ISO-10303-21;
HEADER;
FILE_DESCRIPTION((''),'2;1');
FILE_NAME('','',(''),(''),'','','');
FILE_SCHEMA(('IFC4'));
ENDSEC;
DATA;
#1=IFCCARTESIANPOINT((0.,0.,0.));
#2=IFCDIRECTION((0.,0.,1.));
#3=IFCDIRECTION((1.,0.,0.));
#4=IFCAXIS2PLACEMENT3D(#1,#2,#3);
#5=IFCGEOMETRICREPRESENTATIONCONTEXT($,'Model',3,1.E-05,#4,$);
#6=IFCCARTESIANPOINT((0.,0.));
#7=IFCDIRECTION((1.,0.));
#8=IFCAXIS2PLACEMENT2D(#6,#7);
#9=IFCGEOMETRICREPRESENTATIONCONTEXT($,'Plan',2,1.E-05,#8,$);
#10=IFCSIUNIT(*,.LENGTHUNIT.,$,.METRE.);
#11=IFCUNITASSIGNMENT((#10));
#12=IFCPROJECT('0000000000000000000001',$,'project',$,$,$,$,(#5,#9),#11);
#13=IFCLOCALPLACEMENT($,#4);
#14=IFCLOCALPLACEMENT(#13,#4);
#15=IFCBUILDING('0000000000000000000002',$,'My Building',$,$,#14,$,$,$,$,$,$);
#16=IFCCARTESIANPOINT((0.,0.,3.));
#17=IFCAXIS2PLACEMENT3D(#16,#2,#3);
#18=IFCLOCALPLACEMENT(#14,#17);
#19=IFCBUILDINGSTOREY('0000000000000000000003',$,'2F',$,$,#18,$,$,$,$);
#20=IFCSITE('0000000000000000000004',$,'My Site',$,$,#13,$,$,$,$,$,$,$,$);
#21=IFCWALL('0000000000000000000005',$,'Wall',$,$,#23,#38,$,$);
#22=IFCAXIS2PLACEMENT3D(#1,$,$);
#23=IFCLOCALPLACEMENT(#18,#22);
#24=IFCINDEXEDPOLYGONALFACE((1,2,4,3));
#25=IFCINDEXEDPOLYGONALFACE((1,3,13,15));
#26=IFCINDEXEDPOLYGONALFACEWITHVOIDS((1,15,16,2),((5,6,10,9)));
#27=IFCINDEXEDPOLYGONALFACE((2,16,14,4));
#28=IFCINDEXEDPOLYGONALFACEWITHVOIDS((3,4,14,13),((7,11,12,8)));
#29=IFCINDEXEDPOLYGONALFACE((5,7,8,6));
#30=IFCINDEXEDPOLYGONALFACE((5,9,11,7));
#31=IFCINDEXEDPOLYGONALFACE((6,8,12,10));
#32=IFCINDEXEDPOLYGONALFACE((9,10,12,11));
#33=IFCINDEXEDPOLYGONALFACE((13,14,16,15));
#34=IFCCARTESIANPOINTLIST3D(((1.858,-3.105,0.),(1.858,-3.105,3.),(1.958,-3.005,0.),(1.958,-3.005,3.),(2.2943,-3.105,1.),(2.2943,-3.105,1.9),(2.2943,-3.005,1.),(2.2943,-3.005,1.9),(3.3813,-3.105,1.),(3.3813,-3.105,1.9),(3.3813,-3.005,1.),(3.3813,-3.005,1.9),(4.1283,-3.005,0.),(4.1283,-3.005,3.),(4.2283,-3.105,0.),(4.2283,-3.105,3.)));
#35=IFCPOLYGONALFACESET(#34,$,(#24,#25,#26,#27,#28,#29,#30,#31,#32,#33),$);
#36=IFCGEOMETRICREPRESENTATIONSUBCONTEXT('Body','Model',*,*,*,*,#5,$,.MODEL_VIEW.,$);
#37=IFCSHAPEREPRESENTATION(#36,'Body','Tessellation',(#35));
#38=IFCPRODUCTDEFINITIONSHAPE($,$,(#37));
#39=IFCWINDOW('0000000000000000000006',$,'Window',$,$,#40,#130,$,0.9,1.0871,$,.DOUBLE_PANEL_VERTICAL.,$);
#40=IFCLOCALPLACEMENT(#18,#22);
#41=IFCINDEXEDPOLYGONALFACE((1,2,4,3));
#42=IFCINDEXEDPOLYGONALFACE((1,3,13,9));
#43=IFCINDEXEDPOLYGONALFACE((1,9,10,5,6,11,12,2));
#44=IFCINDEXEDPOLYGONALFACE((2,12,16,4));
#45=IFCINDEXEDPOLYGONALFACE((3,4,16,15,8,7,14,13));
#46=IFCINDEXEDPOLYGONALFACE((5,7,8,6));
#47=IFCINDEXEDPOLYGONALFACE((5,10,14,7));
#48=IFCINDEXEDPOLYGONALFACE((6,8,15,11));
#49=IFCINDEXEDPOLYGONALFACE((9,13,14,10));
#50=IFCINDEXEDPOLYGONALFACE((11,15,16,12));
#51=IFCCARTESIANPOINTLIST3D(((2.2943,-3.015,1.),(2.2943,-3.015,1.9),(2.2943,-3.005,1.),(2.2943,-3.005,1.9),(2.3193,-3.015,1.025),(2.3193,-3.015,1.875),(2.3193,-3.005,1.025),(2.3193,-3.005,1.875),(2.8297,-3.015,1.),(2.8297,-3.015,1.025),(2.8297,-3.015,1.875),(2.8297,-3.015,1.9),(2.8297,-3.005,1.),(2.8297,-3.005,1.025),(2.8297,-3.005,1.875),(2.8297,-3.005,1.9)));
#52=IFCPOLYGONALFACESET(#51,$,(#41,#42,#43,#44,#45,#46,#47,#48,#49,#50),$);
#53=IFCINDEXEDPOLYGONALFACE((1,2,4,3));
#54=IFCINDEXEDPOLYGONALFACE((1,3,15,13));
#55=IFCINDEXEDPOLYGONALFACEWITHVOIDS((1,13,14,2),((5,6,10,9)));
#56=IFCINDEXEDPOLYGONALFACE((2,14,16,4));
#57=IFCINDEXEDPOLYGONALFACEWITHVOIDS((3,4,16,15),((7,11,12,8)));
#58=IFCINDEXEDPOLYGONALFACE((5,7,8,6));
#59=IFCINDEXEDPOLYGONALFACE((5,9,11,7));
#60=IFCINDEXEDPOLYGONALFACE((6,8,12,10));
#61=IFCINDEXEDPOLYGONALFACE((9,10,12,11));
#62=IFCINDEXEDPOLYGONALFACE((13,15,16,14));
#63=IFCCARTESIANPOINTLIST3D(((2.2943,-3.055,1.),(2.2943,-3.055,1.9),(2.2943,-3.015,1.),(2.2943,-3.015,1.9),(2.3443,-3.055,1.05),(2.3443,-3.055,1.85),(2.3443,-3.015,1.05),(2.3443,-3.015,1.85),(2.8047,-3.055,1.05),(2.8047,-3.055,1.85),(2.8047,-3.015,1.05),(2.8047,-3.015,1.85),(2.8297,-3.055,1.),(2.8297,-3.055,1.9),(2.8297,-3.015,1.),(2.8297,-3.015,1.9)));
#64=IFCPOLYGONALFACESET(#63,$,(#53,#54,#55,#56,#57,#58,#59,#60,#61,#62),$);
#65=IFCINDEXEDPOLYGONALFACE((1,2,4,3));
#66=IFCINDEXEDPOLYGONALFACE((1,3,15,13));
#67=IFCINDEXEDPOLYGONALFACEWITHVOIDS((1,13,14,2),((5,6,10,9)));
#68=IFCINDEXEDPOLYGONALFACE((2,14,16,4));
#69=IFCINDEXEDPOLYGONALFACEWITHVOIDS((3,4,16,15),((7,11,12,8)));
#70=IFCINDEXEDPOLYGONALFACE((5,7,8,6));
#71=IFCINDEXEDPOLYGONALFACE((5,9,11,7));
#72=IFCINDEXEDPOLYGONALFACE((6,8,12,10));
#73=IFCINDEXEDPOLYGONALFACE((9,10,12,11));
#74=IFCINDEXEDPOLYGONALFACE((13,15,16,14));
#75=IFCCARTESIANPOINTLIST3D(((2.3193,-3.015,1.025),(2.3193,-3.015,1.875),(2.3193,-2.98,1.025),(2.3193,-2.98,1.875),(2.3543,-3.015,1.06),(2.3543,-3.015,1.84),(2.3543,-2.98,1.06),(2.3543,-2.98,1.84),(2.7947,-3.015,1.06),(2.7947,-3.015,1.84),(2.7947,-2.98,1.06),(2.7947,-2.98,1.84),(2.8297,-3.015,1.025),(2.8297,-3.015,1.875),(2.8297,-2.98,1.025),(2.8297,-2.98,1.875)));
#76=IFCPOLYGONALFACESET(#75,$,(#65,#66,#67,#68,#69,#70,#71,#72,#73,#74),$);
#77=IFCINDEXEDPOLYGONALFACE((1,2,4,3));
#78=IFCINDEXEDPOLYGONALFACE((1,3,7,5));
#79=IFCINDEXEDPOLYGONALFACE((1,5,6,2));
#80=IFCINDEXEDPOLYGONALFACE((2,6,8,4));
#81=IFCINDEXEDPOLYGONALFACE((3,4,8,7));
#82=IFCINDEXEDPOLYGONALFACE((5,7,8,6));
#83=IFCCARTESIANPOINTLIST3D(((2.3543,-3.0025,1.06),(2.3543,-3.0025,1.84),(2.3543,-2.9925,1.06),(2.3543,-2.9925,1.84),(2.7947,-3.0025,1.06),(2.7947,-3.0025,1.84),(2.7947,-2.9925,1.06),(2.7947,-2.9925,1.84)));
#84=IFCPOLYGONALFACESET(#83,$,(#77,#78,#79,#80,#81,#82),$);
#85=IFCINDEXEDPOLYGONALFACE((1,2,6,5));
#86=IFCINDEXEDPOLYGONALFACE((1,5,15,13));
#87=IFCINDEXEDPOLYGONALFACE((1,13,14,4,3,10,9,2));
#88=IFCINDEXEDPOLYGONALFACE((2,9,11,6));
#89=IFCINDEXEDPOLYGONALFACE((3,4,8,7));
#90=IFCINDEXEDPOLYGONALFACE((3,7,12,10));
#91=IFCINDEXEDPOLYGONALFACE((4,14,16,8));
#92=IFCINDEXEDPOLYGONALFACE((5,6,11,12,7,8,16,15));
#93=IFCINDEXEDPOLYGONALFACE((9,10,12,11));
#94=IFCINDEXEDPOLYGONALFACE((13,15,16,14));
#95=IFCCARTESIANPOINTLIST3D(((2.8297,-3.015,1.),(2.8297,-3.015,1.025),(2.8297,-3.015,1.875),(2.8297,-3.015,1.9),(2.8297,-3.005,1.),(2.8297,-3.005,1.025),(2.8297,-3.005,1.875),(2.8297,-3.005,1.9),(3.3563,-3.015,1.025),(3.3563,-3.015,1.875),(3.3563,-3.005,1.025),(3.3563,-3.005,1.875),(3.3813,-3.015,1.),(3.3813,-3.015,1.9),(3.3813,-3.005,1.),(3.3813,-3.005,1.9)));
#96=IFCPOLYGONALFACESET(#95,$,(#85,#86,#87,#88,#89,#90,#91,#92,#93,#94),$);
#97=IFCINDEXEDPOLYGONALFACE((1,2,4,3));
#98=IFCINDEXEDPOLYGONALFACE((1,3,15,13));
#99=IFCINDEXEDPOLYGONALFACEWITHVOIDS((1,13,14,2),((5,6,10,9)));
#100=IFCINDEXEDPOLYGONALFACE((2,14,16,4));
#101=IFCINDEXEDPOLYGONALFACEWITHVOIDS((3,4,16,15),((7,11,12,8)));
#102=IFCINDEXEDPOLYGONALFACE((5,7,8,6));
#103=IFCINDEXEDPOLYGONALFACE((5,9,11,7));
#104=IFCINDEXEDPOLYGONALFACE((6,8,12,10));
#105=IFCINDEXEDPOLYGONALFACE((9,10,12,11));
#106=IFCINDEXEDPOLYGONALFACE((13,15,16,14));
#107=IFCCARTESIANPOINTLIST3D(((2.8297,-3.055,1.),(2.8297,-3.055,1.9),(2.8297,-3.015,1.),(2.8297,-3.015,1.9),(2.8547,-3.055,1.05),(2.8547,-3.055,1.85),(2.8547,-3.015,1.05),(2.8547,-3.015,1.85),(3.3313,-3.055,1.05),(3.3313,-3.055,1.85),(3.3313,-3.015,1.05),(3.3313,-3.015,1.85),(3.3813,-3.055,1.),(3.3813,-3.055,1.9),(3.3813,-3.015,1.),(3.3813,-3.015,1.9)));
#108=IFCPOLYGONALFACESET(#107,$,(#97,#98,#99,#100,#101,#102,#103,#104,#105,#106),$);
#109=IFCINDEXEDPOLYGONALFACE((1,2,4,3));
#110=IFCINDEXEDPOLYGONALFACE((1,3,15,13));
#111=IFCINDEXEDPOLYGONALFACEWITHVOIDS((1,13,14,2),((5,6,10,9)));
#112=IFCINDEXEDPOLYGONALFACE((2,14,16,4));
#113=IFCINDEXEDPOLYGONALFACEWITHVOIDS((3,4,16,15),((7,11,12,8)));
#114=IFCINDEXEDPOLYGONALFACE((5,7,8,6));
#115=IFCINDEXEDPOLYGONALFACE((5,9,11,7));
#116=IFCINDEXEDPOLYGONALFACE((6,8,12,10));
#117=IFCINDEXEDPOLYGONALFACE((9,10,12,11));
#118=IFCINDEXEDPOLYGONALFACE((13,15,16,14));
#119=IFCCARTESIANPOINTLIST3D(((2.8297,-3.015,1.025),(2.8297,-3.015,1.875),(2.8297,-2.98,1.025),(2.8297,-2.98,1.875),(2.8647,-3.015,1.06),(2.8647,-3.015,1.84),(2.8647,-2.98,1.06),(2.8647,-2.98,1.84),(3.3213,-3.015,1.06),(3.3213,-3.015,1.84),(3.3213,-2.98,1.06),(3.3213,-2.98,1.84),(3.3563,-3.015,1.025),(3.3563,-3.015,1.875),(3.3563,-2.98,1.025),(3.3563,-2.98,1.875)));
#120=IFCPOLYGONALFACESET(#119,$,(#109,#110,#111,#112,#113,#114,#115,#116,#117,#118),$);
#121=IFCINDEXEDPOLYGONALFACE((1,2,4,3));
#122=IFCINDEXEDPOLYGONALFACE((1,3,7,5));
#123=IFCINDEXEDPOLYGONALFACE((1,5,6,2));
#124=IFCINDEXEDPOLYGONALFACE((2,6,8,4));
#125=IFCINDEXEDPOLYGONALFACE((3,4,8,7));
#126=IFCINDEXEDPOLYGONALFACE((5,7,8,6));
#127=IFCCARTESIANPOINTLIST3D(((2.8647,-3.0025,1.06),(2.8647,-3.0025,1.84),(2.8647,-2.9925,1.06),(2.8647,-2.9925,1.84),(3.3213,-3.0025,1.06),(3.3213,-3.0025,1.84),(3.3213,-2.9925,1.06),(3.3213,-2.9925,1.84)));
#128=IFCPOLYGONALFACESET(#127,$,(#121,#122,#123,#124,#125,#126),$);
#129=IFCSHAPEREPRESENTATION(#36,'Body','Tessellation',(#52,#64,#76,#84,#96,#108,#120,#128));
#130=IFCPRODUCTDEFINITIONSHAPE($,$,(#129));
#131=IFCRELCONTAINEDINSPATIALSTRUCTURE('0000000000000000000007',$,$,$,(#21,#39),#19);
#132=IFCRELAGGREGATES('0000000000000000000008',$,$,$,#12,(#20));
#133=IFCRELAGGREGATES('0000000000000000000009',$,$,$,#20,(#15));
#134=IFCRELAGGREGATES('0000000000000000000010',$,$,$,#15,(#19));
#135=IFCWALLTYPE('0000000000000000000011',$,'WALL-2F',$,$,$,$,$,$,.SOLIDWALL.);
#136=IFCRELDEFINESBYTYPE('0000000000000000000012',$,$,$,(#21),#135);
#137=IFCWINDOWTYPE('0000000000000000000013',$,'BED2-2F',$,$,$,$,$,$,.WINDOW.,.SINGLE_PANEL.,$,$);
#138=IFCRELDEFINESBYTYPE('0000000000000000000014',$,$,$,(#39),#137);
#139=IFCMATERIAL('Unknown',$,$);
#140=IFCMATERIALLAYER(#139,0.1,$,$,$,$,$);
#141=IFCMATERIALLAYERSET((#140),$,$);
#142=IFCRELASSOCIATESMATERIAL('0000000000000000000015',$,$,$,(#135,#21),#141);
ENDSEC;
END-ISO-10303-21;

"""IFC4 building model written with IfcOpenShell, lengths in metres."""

from ifc_helpers import new_model, entity, si_unit, frame, origin_with_axes, origin_2d_with_axis, place, context, subcontext, project, spatial, line, indexed_curve, outline, extrude, shape, source, transform, mapped, material, layer, layer_set, layer_usage, type_object, type_shapes, element, fill, save


model = new_model("IFC4")

# Units and contexts
model_context = context("Model", 3, precision=1e-05, world=origin_with_axes())
plan_context = context("Plan", 2, precision=1e-05, world=origin_2d_with_axis())
body_context_1 = subcontext(model_context, "Body", "Model", "MODEL_VIEW")
body_context_2 = subcontext(plan_context, "Body", "Plan", "PLAN_VIEW")
ifc_project = project(units=[si_unit("LENGTHUNIT", "METRE")], contexts=[model_context, plan_context])

# Site, building, storey
site_placement = place(None, origin_with_axes())
site = spatial("IfcSite", under=ifc_project, at=site_placement, Name="My Site")
building_placement = place(site_placement, origin_with_axes())
building = spatial("IfcBuilding", under=site, at=building_placement, Name="My Building")
storey_placement = place(building_placement, frame((0.0, 0.0, 3.0), z_axis=(0.0, 0.0, 1.0), x_axis=(1.0, 0.0, 0.0)))
storey = spatial("IfcBuildingStorey", under=building, at=storey_placement, Name="2F")

# Shared definitions
ifc_material = material(Name="Unknown")

# Shared definitions
ifc_layer_1 = layer(ifc_material, 0.1)
ifc_layer_set_1 = layer_set([ifc_layer_1])
wall_type = type_object("IfcWallType", Name="WALL-2F", PredefinedType="SOLIDWALL", material=ifc_layer_set_1)

# Wall, opening, window
ifc_layer_usage_1 = layer_usage(ifc_layer_set_1, "AXIS2", "POSITIVE", 0.0)
wall_1_placement = place(storey_placement, frame((1.858, -3.105, 0.0), z_axis=(0.0, 0.0, 1.0), x_axis=(1.0, 0.0, 0.0)))
wall_1 = element("IfcWall", 1, at=wall_1_placement, inside=storey, type_object=wall_type, material=ifc_layer_usage_1, Name="Wall", context=body_context_1, shape_type="SweptSolid", body=[
    extrude(outline(indexed_curve([(0.0, 0.0), (0.1, 0.1), (2.2703, 0.1), (2.3703, 0.0)], segments=[line(1, 2, 3, 4, 1)])), origin_with_axes(), (0.0, 0.0, 1.0), 3.0),
])
shared_shape_1 = source(origin_with_axes(), body_context_1, "Body", "SweptSolid", [
    extrude(outline(indexed_curve([(0.0, 0.0), (1.0871, 0.0), (1.0871, 0.9), (0.0, 0.9)], segments=[line(1, 2, 3, 4, 1)])), frame((0.0, -0.6, 0.0), z_axis=(0.0, -1.0, 0.0), x_axis=(1.0, 0.0, 0.0)), (0.0, 0.0, -1.0), 1.2),
])
opening_1_placement = place(wall_1_placement, frame((0.4363, 0.0, 1.0), z_axis=(0.0, 0.0, 1.0), x_axis=(1.0, 0.0, 0.0)))
opening_1 = element("IfcOpeningElement", 2, at=opening_1_placement, cuts=wall_1, PredefinedType="OPENING", context=body_context_1, shape_type="MappedRepresentation", body=[
    mapped(shared_shape_1, transform((0.0, 0.0, 0.0), x_axis=(1.0, 0.0, 0.0), y_axis=(0.0, 1.0, 0.0), z_axis=(0.0, 0.0, 1.0), scale=1.0)),
])
window_type = type_object("IfcWindowType", Name="BED2-2F", PartitioningType="SINGLE_PANEL", PredefinedType="WINDOW")
shared_shape_2 = source(origin_with_axes(), body_context_1, "Body", "SweptSolid", [
    extrude(outline(indexed_curve([(0.5354, 0.0), (0.0, 0.0), (0.0, 0.9), (0.5354, 0.9), (0.5354, 0.875), (0.025, 0.875), (0.025, 0.025), (0.5354, 0.025)], segments=[line(1, 2, 3, 4, 5, 6, 7, 8, 1)])), frame((0.0, 0.09, 0.0), z_axis=(0.0, -1.0, 0.0), x_axis=(1.0, 0.0, 0.0)), (0.0, 0.0, -1.0), 0.01),
    extrude(outline(indexed_curve([(0.0, 0.0), (0.5354, 0.0), (0.5354, 0.9), (0.0, 0.9)], segments=[line(1, 2, 3, 4, 1)]), holes=[indexed_curve([(0.05, 0.05), (0.5104, 0.05), (0.5104, 0.85), (0.05, 0.85)], segments=[line(1, 2, 3, 4, 1)])]), frame((0.0, 0.05, 0.0), z_axis=(0.0, -1.0, 0.0), x_axis=(1.0, 0.0, 0.0)), (0.0, 0.0, -1.0), 0.04),
    extrude(outline(indexed_curve([(0.0, 0.0), (0.5104, 0.0), (0.5104, 0.85), (0.0, 0.85)], segments=[line(1, 2, 3, 4, 1)]), holes=[indexed_curve([(0.035, 0.035), (0.4754, 0.035), (0.4754, 0.815), (0.035, 0.815)], segments=[line(1, 2, 3, 4, 1)])]), frame((0.025, 0.09, 0.025), z_axis=(0.0, -1.0, 0.0), x_axis=(1.0, 0.0, 0.0)), (0.0, 0.0, -1.0), 0.035),
    extrude(outline(indexed_curve([(0.035, 0.035), (0.4754, 0.035), (0.4754, 0.815), (0.035, 0.815)], segments=[line(1, 2, 3, 4, 1)])), frame((0.025, 0.1025, 0.025), z_axis=(0.0, -1.0, 0.0), x_axis=(1.0, 0.0, 0.0)), (0.0, 0.0, -1.0), 0.01),
    extrude(outline(indexed_curve([(0.0, 0.9), (0.5516, 0.9), (0.5516, 0.0), (0.0, 0.0), (0.0, 0.025), (0.5266, 0.025), (0.5266, 0.875), (0.0, 0.875)], segments=[line(1, 2, 3, 4, 5, 6, 7, 8, 1)])), frame((0.5354, 0.09, 0.0), z_axis=(0.0, -1.0, 0.0), x_axis=(1.0, 0.0, 0.0)), (0.0, 0.0, -1.0), 0.01),
    extrude(outline(indexed_curve([(0.0, 0.0), (0.5516, 0.0), (0.5516, 0.9), (0.0, 0.9)], segments=[line(1, 2, 3, 4, 1)]), holes=[indexed_curve([(0.025, 0.05), (0.5016, 0.05), (0.5016, 0.85), (0.025, 0.85)], segments=[line(1, 2, 3, 4, 1)])]), frame((0.5354, 0.05, 0.0), z_axis=(0.0, -1.0, 0.0), x_axis=(1.0, 0.0, 0.0)), (0.0, 0.0, -1.0), 0.04),
    extrude(outline(indexed_curve([(0.0, 0.0), (0.5266, 0.0), (0.5266, 0.85), (0.0, 0.85)], segments=[line(1, 2, 3, 4, 1)]), holes=[indexed_curve([(0.035, 0.035), (0.4916, 0.035), (0.4916, 0.815), (0.035, 0.815)], segments=[line(1, 2, 3, 4, 1)])]), frame((0.5354, 0.09, 0.025), z_axis=(0.0, -1.0, 0.0), x_axis=(1.0, 0.0, 0.0)), (0.0, 0.0, -1.0), 0.035),
    extrude(outline(indexed_curve([(0.035, 0.035), (0.4916, 0.035), (0.4916, 0.815), (0.035, 0.815)], segments=[line(1, 2, 3, 4, 1)])), frame((0.5354, 0.1025, 0.025), z_axis=(0.0, -1.0, 0.0), x_axis=(1.0, 0.0, 0.0)), (0.0, 0.0, -1.0), 0.01),
])
shared_shape_3 = source(origin_with_axes(), body_context_2, "Body", "Curve2D", [
    entity("IfcIndexedPolyCurve", entity("IfcCartesianPointList2D", [[0.05, 0.05], [0.5104, 0.05]])),
    entity("IfcIndexedPolyCurve", entity("IfcCartesianPointList2D", [[0.0, 0.1], [0.025, 0.1], [0.025, 0.09], [0.05, 0.09], [0.05, 0.05], [0.0, 0.05]]), [entity("IfcLineIndex", [1, 2, 3, 4, 5, 6, 1])]),
    entity("IfcIndexedPolyCurve", entity("IfcCartesianPointList2D", [[0.5354, 0.1], [0.5354, 0.1], [0.5354, 0.09], [0.5104, 0.09], [0.5104, 0.05], [0.5354, 0.05]])),
    entity("IfcIndexedPolyCurve", entity("IfcCartesianPointList2D", [[0.025, 0.09], [0.06, 0.09], [0.06, 0.125], [0.025, 0.125]]), [entity("IfcLineIndex", [1, 2, 3, 4, 1])]),
    entity("IfcIndexedPolyCurve", entity("IfcCartesianPointList2D", [[0.5354, 0.09], [0.5004, 0.09], [0.5004, 0.125], [0.5354, 0.125]]), [entity("IfcLineIndex", [1, 2, 3, 4, 1])]),
    entity("IfcIndexedPolyCurve", entity("IfcCartesianPointList2D", [[0.06, 0.09], [0.5004, 0.09]])),
    entity("IfcIndexedPolyCurve", entity("IfcCartesianPointList2D", [[0.06, 0.125], [0.5004, 0.125]])),
    entity("IfcIndexedPolyCurve", entity("IfcCartesianPointList2D", [[0.06, 0.1075], [0.5004, 0.1075]])),
    entity("IfcIndexedPolyCurve", entity("IfcCartesianPointList2D", [[0.5604, 0.05], [1.0371, 0.05]])),
    entity("IfcIndexedPolyCurve", entity("IfcCartesianPointList2D", [[0.5354, 0.1], [0.5354, 0.1], [0.5354, 0.09], [0.5604, 0.09], [0.5604, 0.05], [0.5354, 0.05]])),
    entity("IfcIndexedPolyCurve", entity("IfcCartesianPointList2D", [[1.0871, 0.1], [1.0621, 0.1], [1.0621, 0.09], [1.0371, 0.09], [1.0371, 0.05], [1.0871, 0.05]]), [entity("IfcLineIndex", [1, 2, 3, 4, 5, 6, 1])]),
    entity("IfcIndexedPolyCurve", entity("IfcCartesianPointList2D", [[0.5354, 0.09], [0.5704, 0.09], [0.5704, 0.125], [0.5354, 0.125]]), [entity("IfcLineIndex", [1, 2, 3, 4, 1])]),
    entity("IfcIndexedPolyCurve", entity("IfcCartesianPointList2D", [[1.0621, 0.09], [1.0271, 0.09], [1.0271, 0.125], [1.0621, 0.125]]), [entity("IfcLineIndex", [1, 2, 3, 4, 1])]),
    entity("IfcIndexedPolyCurve", entity("IfcCartesianPointList2D", [[0.5704, 0.09], [1.0271, 0.09]])),
    entity("IfcIndexedPolyCurve", entity("IfcCartesianPointList2D", [[0.5704, 0.125], [1.0271, 0.125]])),
    entity("IfcIndexedPolyCurve", entity("IfcCartesianPointList2D", [[0.5704, 0.1075], [1.0271, 0.1075]])),
])
type_shapes(window_type, [shared_shape_2, shared_shape_3])
window_placement = place(opening_1_placement, origin_with_axes())
window = element("IfcWindow", 3, at=window_placement, inside=storey, type_object=window_type, Name="Window", OverallHeight=0.9, OverallWidth=1.0871, PartitioningType="DOUBLE_PANEL_VERTICAL", shapes=[
    shape(body_context_1, "Body", "MappedRepresentation", [mapped(shared_shape_2, transform((0.0, 0.0, 0.0), x_axis=(1.0, 0.0, 0.0), y_axis=(0.0, 1.0, 0.0), z_axis=(0.0, 0.0, 1.0), scale=1.0))]),
    shape(body_context_2, "Body", "MappedRepresentation", [mapped(shared_shape_3, transform((0.0, 0.0, 0.0), x_axis=(1.0, 0.0, 0.0), y_axis=(0.0, 1.0, 0.0), z_axis=(0.0, 0.0, 1.0), scale=1.0))]),
])
fill(opening_1, window)

save(model, "model.ifc")
